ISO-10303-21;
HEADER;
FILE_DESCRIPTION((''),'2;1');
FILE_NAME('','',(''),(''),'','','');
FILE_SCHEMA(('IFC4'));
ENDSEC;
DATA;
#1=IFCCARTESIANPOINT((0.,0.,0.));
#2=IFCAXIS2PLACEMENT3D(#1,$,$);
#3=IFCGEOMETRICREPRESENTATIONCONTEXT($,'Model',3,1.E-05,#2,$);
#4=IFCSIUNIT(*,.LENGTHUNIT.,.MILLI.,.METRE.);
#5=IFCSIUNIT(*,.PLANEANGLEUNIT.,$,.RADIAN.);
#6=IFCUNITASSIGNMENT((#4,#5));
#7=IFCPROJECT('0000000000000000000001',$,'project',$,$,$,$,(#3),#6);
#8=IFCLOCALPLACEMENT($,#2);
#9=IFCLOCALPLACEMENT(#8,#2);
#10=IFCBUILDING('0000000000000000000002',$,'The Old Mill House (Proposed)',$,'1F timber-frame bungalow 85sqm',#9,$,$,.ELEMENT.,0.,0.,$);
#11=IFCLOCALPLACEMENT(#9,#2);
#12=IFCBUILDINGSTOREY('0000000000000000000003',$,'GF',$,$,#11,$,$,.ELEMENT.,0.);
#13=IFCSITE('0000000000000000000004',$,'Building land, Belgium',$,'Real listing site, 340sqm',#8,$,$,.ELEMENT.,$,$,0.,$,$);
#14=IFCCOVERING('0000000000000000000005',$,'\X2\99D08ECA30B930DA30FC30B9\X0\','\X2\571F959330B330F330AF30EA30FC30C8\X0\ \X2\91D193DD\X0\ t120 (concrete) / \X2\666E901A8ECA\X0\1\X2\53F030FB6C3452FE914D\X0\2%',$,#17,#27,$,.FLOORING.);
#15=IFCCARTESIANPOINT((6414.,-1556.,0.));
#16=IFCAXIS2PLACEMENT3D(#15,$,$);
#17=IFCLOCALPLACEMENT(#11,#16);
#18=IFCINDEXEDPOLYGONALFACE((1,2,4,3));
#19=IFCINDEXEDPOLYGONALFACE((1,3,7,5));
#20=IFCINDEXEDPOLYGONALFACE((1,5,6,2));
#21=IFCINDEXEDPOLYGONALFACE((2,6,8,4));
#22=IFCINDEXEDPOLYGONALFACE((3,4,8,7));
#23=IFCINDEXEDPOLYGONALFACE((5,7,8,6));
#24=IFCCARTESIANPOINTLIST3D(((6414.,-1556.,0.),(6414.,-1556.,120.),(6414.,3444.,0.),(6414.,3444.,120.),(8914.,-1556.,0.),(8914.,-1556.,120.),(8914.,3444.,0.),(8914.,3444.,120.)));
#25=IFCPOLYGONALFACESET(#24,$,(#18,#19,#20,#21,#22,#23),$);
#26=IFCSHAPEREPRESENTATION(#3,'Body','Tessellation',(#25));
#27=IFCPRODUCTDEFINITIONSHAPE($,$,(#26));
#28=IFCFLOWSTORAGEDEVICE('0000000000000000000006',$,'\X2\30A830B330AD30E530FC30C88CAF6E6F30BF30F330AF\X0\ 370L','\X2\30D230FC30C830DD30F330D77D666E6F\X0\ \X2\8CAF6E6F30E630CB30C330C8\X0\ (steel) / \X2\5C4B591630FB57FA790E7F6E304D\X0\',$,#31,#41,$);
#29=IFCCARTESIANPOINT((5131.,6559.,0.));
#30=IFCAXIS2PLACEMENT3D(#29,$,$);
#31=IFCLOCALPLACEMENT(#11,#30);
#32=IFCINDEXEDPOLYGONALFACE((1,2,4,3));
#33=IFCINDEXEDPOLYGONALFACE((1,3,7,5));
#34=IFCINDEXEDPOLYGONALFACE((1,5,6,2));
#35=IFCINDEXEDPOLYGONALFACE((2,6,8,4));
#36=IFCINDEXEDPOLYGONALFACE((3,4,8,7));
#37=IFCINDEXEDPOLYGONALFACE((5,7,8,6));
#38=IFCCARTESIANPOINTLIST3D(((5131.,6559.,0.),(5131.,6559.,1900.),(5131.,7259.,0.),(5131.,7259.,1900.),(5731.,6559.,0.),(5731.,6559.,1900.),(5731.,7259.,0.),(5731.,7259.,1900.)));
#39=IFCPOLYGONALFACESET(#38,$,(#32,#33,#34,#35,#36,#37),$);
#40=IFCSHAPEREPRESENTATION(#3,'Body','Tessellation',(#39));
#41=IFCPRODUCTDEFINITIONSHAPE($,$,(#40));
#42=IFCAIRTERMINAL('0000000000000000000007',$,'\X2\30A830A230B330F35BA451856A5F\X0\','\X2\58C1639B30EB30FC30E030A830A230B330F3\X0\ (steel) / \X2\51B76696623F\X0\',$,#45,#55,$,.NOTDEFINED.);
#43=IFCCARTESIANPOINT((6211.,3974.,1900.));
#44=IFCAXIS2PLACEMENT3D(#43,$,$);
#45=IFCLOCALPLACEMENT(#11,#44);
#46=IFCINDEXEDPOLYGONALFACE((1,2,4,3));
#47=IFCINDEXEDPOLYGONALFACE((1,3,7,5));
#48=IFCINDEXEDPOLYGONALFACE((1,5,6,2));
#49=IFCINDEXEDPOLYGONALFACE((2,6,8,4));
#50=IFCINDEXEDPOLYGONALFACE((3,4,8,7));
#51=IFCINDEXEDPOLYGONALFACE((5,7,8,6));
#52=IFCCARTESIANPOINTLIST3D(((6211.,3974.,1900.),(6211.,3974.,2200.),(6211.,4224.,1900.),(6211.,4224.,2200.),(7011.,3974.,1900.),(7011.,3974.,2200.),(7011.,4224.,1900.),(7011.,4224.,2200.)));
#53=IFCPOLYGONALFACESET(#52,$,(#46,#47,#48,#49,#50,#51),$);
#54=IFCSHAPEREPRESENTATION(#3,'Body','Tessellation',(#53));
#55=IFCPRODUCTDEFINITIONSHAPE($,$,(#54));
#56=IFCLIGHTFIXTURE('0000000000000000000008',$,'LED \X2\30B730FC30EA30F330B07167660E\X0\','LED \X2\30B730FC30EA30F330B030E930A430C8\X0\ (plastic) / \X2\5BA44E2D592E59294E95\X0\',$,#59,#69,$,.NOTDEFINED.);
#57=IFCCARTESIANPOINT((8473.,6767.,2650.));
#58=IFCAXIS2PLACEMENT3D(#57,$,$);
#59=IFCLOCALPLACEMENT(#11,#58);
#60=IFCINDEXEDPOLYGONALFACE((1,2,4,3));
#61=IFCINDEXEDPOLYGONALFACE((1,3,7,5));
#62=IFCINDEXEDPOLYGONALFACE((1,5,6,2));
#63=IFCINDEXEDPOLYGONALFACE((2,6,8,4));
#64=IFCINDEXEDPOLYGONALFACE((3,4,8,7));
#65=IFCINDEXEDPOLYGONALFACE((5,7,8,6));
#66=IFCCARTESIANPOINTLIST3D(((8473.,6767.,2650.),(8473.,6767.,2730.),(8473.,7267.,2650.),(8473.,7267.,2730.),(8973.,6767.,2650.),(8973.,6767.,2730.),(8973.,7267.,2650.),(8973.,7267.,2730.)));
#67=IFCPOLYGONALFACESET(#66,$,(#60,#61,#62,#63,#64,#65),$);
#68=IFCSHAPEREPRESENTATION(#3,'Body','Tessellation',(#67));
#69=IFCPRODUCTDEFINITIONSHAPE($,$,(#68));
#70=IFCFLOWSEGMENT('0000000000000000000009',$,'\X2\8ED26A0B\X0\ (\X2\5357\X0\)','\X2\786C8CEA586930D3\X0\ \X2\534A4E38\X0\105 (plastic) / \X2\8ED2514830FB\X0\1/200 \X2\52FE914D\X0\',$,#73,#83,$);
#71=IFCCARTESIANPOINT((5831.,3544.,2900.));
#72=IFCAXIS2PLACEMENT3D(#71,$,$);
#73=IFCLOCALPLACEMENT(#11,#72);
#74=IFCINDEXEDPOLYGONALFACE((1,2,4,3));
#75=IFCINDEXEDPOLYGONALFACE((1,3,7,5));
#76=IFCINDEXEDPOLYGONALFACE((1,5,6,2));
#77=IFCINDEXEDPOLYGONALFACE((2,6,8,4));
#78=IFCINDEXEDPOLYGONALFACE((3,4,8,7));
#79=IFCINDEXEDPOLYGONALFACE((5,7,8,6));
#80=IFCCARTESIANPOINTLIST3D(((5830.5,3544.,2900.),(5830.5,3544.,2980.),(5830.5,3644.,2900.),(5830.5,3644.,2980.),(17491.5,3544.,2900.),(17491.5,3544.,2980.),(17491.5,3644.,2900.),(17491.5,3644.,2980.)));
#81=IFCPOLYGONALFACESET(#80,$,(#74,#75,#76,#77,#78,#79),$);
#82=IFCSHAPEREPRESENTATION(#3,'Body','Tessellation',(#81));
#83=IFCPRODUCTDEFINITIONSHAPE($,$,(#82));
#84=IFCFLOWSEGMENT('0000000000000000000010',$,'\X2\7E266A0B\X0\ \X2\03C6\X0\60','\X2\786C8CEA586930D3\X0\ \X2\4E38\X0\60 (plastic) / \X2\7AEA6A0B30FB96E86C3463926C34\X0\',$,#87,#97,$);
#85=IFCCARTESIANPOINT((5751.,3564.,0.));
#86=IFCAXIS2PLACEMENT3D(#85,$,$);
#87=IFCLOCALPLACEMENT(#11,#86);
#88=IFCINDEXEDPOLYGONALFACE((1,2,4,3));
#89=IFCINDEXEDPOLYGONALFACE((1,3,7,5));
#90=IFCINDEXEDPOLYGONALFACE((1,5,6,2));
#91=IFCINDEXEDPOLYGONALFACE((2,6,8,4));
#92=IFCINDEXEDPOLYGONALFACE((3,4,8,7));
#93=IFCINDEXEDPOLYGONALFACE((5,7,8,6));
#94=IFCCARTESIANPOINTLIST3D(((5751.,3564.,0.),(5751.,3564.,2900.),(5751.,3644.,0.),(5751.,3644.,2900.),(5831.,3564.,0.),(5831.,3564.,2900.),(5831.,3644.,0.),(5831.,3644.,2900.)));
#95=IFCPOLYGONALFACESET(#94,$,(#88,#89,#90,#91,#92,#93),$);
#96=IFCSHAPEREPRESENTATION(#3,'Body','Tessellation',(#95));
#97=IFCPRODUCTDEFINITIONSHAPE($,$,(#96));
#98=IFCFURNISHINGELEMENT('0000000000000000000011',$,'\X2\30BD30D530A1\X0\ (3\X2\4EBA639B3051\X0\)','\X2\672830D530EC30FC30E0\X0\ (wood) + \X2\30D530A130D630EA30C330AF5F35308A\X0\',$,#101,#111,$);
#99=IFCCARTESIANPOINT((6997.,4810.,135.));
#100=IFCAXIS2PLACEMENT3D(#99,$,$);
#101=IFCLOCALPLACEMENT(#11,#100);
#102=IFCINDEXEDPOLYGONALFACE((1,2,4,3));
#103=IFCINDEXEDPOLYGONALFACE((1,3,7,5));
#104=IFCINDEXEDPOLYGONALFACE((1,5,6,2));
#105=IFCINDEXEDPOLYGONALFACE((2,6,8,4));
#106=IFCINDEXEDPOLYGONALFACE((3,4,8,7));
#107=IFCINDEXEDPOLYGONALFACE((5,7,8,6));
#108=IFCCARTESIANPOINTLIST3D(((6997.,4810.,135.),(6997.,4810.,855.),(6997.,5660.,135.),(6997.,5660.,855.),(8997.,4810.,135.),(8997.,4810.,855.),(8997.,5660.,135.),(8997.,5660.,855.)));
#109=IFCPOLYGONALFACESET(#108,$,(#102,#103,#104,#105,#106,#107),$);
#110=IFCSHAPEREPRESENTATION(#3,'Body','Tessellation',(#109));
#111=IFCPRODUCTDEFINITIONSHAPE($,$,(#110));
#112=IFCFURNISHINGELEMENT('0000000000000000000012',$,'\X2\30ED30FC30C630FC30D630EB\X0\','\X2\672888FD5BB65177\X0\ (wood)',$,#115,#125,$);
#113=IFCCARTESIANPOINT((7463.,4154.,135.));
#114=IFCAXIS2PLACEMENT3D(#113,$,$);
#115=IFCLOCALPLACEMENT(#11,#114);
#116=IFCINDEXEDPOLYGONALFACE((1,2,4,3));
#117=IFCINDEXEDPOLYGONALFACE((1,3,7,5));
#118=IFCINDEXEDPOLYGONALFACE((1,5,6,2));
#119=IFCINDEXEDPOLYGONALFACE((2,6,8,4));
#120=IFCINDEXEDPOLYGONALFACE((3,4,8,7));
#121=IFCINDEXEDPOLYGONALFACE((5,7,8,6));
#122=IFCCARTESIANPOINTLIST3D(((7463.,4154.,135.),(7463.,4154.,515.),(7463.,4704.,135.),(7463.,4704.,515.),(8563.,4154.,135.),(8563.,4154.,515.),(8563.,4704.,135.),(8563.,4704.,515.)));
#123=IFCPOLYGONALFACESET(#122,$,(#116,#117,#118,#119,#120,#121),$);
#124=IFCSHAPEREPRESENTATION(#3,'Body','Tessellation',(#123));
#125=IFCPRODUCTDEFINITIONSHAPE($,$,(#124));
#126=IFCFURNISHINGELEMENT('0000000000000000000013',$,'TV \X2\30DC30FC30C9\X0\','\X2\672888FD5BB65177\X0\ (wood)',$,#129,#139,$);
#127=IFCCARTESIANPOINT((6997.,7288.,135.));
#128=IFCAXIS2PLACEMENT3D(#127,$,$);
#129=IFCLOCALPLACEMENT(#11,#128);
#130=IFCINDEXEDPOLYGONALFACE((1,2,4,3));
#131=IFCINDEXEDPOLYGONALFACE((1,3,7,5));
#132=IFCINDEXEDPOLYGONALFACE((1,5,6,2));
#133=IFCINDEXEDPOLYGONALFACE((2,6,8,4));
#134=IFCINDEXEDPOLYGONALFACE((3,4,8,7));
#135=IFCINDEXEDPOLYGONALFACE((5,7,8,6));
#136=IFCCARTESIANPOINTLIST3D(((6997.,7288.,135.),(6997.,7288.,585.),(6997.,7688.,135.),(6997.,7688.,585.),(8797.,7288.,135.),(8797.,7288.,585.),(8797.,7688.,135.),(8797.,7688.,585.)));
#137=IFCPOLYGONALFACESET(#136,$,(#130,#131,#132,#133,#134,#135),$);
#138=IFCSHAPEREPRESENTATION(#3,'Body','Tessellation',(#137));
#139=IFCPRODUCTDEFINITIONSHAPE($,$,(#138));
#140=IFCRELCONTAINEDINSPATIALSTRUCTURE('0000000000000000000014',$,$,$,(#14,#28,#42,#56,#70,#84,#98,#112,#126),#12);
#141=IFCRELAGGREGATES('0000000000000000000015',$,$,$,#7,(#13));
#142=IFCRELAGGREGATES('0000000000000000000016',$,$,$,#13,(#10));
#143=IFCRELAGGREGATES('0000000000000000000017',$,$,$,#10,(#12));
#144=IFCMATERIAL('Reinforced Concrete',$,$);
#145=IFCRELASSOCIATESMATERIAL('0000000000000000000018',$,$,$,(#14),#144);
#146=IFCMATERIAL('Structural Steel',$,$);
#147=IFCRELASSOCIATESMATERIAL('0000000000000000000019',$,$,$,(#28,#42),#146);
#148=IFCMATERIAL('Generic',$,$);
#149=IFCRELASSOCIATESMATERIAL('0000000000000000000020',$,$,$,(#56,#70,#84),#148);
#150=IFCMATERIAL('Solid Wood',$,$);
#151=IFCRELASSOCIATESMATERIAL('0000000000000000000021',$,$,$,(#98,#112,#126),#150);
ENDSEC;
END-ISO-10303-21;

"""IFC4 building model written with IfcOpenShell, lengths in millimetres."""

from ifc_helpers import new_model, si_unit, frame, frame_2d, origin, place, context, project, spatial, rectangle, extrude, material, element, save


model = new_model("IFC4")

# Units and contexts
model_context = context("Model", 3, precision=1e-05, world=origin())
ifc_project = project(units=[si_unit("LENGTHUNIT", "METRE", prefix="MILLI"), si_unit("PLANEANGLEUNIT", "RADIAN")], contexts=[model_context])

# Site, building, storey
site_placement = place(None, origin())
site = spatial("IfcSite", under=ifc_project, at=site_placement, Name="Building land, Belgium", ObjectType="Real listing site, 340sqm", CompositionType="ELEMENT", RefElevation=0.0)
building_placement = place(site_placement, origin())
building = spatial("IfcBuilding", under=site, at=building_placement, Name="The Old Mill House (Proposed)", ObjectType="1F timber-frame bungalow 85sqm", CompositionType="ELEMENT", ElevationOfRefHeight=0.0, ElevationOfTerrain=0.0)
storey_placement = place(building_placement, origin())
storey = spatial("IfcBuildingStorey", under=building, at=storey_placement, Name="GF", CompositionType="ELEMENT", Elevation=0.0)

# Shared definitions
ifc_material_1 = material(Name="Solid Wood")

# Shared definitions
ifc_material_2 = material(Name="Reinforced Concrete")

# Shared definitions
ifc_material_3 = material(Name="Structural Steel")

# Covering
ifc_material_4 = material(Name="Generic")
covering_1_placement = place(storey_placement, frame((6414.0, -1556.0, 0.0)))
element("IfcCovering", 1, at=covering_1_placement, inside=storey, material=ifc_material_2, Name="駐車スペース", Description="土間コンクリート 金鏝 t120 (concrete) / 普通車1台・水勾配2%", PredefinedType="FLOORING", context=model_context, shape_type="SweptSolid", body=[
    extrude(rectangle(XDim=2500.0, YDim=5000.0, at=frame_2d((1250.0, 2500.0))), frame((6414.0, -1556.0, 0.0)), (0.0, 0.0, 1.0), 120.0),
])

# Flow storage device
flow_storage_device_placement = place(storey_placement, frame((5131.0, 6559.0, 0.0)))
element("IfcFlowStorageDevice", 2, at=flow_storage_device_placement, inside=storey, material=ifc_material_3, Name="エコキュート貯湯タンク 370L", Description="ヒートポンプ給湯 貯湯ユニット (steel) / 屋外・基礎置き", context=model_context, shape_type="SweptSolid", body=[
    extrude(rectangle(XDim=600.0, YDim=700.0, at=frame_2d((300.0, 350.0))), frame((5131.0, 6559.0, 0.0)), (0.0, 0.0, 1.0), 1900.0),
])

# Air terminal
air_terminal_placement = place(storey_placement, frame((6211.0, 3974.0, 1900.0)))
element("IfcAirTerminal", 3, at=air_terminal_placement, inside=storey, material=ifc_material_3, Name="エアコン室内機", Description="壁掛ルームエアコン (steel) / 冷暖房", PredefinedType="NOTDEFINED", context=model_context, shape_type="SweptSolid", body=[
    extrude(rectangle(XDim=800.0, YDim=250.0, at=frame_2d((400.0, 125.0))), frame((6211.0, 3974.0, 1900.0)), (0.0, 0.0, 1.0), 300.0),
])

# Light fixture
light_fixture_placement = place(storey_placement, frame((8473.0, 6767.0, 2650.0)))
element("IfcLightFixture", 4, at=light_fixture_placement, inside=storey, material=ifc_material_4, Name="LED シーリング照明", Description="LED シーリングライト (plastic) / 室中央天井", PredefinedType="NOTDEFINED", context=model_context, shape_type="SweptSolid", body=[
    extrude(rectangle(XDim=500.0, YDim=500.0, at=frame_2d((250.0, 250.0))), frame((8473.0, 6767.0, 2650.0)), (0.0, 0.0, 1.0), 80.0),
])

# Flow segments
flow_segment_1_placement = place(storey_placement, frame((5831.0, 3544.0, 2900.0)))
element("IfcFlowSegment", 5, at=flow_segment_1_placement, inside=storey, material=ifc_material_4, Name="軒樋 (南)", Description="硬質塩ビ 半丸105 (plastic) / 軒先・1/200 勾配", context=model_context, shape_type="SweptSolid", body=[
    extrude(rectangle(XDim=11661.0, YDim=100.0, at=frame_2d((5830.0, 50.0))), frame((5831.0, 3544.0, 2900.0)), (0.0, 0.0, 1.0), 80.0),
])
flow_segment_2_placement = place(storey_placement, frame((5751.0, 3564.0, 0.0)))
element("IfcFlowSegment", 6, at=flow_segment_2_placement, inside=storey, material=ifc_material_4, Name="縦樋 φ60", Description="硬質塩ビ 丸60 (plastic) / 竪樋・雨水排水", context=model_context, shape_type="SweptSolid", body=[
    extrude(rectangle(XDim=80.0, YDim=80.0, at=frame_2d((40.0, 40.0))), frame((5751.0, 3564.0, 0.0)), (0.0, 0.0, 1.0), 2900.0),
])

# Furnishing elements
furnishing_1_placement = place(storey_placement, frame((6997.0, 4810.0, 135.0)))
element("IfcFurnishingElement", 7, at=furnishing_1_placement, inside=storey, material=ifc_material_1, Name="ソファ (3人掛け)", Description="木フレーム (wood) + ファブリック張り", context=model_context, shape_type="SweptSolid", body=[
    extrude(rectangle(XDim=2000.0, YDim=850.0, at=frame_2d((1000.0, 425.0))), frame((6997.0, 4810.0, 135.0)), (0.0, 0.0, 1.0), 720.0),
])
furnishing_2_placement = place(storey_placement, frame((7463.0, 4154.0, 135.0)))
element("IfcFurnishingElement", 8, at=furnishing_2_placement, inside=storey, material=ifc_material_1, Name="ローテーブル", Description="木製家具 (wood)", context=model_context, shape_type="SweptSolid", body=[
    extrude(rectangle(XDim=1100.0, YDim=550.0, at=frame_2d((550.0, 275.0))), frame((7463.0, 4154.0, 135.0)), (0.0, 0.0, 1.0), 380.0),
])
furnishing_3_placement = place(storey_placement, frame((6997.0, 7288.0, 135.0)))
element("IfcFurnishingElement", 9, at=furnishing_3_placement, inside=storey, material=ifc_material_1, Name="TV ボード", Description="木製家具 (wood)", context=model_context, shape_type="SweptSolid", body=[
    extrude(rectangle(XDim=1800.0, YDim=400.0, at=frame_2d((900.0, 200.0))), frame((6997.0, 7288.0, 135.0)), (0.0, 0.0, 1.0), 450.0),
])

save(model, "model.ifc")
